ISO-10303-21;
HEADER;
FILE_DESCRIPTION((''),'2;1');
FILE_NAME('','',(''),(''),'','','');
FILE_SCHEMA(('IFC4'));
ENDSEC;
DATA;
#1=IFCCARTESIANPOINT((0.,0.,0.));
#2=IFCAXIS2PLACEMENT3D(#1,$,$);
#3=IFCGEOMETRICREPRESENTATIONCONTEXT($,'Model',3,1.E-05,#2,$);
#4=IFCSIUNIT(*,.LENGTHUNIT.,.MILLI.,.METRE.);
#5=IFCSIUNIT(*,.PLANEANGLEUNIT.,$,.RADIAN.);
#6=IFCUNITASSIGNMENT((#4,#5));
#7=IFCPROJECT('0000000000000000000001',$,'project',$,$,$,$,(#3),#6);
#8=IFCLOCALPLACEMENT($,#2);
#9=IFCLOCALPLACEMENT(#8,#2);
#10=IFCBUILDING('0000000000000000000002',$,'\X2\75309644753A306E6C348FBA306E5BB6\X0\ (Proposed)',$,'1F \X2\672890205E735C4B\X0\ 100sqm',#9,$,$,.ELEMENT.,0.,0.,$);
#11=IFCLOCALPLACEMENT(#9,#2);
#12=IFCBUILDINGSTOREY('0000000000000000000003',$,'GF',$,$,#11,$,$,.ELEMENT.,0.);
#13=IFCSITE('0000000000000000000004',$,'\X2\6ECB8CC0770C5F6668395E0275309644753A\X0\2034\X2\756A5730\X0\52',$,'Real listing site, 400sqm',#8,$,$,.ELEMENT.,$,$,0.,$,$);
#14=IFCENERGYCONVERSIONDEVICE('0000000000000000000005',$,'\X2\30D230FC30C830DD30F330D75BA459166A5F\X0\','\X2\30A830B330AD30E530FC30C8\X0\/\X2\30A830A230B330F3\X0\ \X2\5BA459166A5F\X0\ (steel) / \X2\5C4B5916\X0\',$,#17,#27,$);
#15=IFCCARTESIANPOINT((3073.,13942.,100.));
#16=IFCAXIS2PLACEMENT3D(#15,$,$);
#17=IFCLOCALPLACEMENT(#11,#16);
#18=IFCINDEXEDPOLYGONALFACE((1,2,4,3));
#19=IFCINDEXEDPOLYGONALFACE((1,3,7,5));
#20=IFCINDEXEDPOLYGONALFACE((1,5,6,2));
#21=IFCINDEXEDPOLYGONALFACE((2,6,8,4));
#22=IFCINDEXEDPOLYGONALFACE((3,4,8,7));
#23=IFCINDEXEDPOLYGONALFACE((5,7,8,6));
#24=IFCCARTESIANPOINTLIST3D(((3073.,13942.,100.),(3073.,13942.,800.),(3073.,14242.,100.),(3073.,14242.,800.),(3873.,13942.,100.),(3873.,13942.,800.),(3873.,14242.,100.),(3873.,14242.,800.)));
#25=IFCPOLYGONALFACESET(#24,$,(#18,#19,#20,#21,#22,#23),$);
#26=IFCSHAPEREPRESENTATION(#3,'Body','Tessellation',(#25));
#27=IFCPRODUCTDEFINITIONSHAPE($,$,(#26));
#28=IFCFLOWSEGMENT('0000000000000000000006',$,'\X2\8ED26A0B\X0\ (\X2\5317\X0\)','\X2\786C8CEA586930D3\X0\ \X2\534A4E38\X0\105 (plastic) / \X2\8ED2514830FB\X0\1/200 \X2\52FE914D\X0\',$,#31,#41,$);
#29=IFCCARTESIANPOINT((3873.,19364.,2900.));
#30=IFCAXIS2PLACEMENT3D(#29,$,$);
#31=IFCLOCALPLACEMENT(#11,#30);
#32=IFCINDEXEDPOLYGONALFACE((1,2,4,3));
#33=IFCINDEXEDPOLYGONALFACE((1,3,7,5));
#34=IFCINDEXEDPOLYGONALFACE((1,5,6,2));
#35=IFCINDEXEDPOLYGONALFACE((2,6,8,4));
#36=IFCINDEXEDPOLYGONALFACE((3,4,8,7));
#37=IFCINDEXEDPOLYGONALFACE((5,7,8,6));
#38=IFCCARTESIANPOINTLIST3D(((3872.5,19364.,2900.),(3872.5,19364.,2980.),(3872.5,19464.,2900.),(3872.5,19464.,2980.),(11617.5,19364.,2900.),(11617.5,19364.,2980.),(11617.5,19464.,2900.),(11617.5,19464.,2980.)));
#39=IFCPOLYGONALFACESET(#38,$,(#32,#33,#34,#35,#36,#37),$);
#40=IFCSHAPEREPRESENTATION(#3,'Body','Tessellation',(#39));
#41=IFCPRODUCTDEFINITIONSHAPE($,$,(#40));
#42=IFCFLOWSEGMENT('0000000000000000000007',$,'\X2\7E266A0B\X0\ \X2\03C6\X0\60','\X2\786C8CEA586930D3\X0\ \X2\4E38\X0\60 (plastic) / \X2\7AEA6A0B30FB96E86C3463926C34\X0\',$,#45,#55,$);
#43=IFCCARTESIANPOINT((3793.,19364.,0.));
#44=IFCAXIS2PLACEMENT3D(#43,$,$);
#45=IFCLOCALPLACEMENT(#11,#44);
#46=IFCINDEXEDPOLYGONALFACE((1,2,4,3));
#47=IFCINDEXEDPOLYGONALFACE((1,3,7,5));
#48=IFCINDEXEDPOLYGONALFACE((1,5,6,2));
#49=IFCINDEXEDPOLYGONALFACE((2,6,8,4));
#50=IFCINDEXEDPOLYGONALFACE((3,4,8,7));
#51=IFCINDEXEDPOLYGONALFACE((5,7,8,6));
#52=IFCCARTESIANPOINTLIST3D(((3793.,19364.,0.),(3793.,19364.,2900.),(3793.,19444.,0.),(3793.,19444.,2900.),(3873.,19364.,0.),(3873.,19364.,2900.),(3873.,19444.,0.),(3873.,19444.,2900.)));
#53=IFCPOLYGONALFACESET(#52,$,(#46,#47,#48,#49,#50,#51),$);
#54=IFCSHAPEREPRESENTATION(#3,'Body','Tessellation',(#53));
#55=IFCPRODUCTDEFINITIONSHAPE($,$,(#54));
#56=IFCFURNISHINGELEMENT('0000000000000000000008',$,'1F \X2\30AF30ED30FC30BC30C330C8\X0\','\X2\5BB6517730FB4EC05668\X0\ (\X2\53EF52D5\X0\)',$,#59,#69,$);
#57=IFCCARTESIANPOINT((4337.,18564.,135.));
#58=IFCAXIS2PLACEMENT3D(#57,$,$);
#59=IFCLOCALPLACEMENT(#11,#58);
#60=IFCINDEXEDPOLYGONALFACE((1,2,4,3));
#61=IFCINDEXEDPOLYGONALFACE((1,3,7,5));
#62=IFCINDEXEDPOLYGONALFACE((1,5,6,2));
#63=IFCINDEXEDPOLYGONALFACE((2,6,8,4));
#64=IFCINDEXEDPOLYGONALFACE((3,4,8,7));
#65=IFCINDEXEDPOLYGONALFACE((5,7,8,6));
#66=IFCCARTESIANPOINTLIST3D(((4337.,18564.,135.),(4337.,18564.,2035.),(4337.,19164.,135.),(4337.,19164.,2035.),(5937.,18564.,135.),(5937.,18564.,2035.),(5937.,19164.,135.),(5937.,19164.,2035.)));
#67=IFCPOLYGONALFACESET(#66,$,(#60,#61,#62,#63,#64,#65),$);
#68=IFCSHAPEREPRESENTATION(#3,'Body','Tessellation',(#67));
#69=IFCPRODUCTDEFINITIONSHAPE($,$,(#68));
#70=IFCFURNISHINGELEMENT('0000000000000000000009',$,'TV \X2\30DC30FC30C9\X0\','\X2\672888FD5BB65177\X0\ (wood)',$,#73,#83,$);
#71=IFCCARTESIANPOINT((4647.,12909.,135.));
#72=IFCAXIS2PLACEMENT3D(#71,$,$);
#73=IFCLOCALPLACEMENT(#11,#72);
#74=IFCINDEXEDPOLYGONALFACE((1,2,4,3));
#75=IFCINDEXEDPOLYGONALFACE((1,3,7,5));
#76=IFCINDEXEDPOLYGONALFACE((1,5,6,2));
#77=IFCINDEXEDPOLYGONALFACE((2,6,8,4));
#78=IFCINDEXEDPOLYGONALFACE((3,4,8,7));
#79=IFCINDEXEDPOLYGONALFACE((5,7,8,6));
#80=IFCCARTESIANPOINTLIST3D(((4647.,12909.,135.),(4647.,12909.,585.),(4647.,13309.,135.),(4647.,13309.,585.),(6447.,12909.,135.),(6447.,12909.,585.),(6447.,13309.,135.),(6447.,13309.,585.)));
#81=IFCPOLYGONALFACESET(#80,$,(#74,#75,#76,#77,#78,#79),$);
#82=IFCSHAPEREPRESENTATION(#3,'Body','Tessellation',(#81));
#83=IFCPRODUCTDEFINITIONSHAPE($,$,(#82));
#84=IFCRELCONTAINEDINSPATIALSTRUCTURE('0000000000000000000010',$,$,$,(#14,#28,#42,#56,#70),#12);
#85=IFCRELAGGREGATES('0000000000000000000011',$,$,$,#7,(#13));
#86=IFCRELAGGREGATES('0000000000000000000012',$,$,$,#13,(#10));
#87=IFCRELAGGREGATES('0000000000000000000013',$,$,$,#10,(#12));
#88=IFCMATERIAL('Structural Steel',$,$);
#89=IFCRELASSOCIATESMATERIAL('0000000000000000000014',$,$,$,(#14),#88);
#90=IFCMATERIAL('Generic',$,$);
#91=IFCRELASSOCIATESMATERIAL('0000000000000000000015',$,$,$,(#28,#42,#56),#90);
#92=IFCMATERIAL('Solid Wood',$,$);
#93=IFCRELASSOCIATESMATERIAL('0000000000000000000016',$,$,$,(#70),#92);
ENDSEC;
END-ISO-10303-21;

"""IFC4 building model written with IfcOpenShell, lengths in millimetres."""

from ifc_helpers import new_model, si_unit, frame, frame_2d, origin, place, context, project, spatial, rectangle, extrude, material, element, save


model = new_model("IFC4")

# Units and contexts
model_context = context("Model", 3, precision=1e-05, world=origin())
ifc_project = project(units=[si_unit("LENGTHUNIT", "METRE", prefix="MILLI"), si_unit("PLANEANGLEUNIT", "RADIAN")], contexts=[model_context])

# Site, building, storey
site_placement = place(None, origin())
site = spatial("IfcSite", under=ifc_project, at=site_placement, Name="滋賀県彦根市田附町2034番地52", ObjectType="Real listing site, 400sqm", CompositionType="ELEMENT", RefElevation=0.0)
building_placement = place(site_placement, origin())
building = spatial("IfcBuilding", under=site, at=building_placement, Name="田附町の水辺の家 (Proposed)", ObjectType="1F 木造平屋 100sqm", CompositionType="ELEMENT", ElevationOfRefHeight=0.0, ElevationOfTerrain=0.0)
storey_placement = place(building_placement, origin())
storey = spatial("IfcBuildingStorey", under=building, at=storey_placement, Name="GF", CompositionType="ELEMENT", Elevation=0.0)

# Shared definitions
ifc_material_1 = material(Name="Solid Wood")

# Shared definitions
ifc_material_2 = material(Name="Structural Steel")

# Shared definitions
ifc_material_3 = material(Name="Generic")

# Energy conversion device
energy_conversion_device_placement = place(storey_placement, frame((3073.0, 13942.0, 100.0)))
element("IfcEnergyConversionDevice", 1, at=energy_conversion_device_placement, inside=storey, material=ifc_material_2, Name="ヒートポンプ室外機", Description="エコキュート/エアコン 室外機 (steel) / 屋外", context=model_context, shape_type="SweptSolid", body=[
    extrude(rectangle(XDim=800.0, YDim=300.0, at=frame_2d((400.0, 150.0))), frame((3073.0, 13942.0, 100.0)), (0.0, 0.0, 1.0), 700.0),
])

# Flow segments
flow_segment_1_placement = place(storey_placement, frame((3873.0, 19364.0, 2900.0)))
element("IfcFlowSegment", 2, at=flow_segment_1_placement, inside=storey, material=ifc_material_3, Name="軒樋 (北)", Description="硬質塩ビ 半丸105 (plastic) / 軒先・1/200 勾配", context=model_context, shape_type="SweptSolid", body=[
    extrude(rectangle(XDim=7745.0, YDim=100.0, at=frame_2d((3872.0, 50.0))), frame((3873.0, 19364.0, 2900.0)), (0.0, 0.0, 1.0), 80.0),
])
flow_segment_2_placement = place(storey_placement, frame((3793.0, 19364.0, 0.0)))
element("IfcFlowSegment", 3, at=flow_segment_2_placement, inside=storey, material=ifc_material_3, Name="縦樋 φ60", Description="硬質塩ビ 丸60 (plastic) / 竪樋・雨水排水", context=model_context, shape_type="SweptSolid", body=[
    extrude(rectangle(XDim=80.0, YDim=80.0, at=frame_2d((40.0, 40.0))), frame((3793.0, 19364.0, 0.0)), (0.0, 0.0, 1.0), 2900.0),
])

# Furnishing elements
furnishing_1_placement = place(storey_placement, frame((4337.0, 18564.0, 135.0)))
element("IfcFurnishingElement", 4, at=furnishing_1_placement, inside=storey, material=ifc_material_3, Name="1F クローゼット", Description="家具・什器 (可動)", context=model_context, shape_type="SweptSolid", body=[
    extrude(rectangle(XDim=1600.0, YDim=600.0, at=frame_2d((800.0, 300.0))), frame((4337.0, 18564.0, 135.0)), (0.0, 0.0, 1.0), 1900.0),
])
furnishing_2_placement = place(storey_placement, frame((4647.0, 12909.0, 135.0)))
element("IfcFurnishingElement", 5, at=furnishing_2_placement, inside=storey, material=ifc_material_1, Name="TV ボード", Description="木製家具 (wood)", context=model_context, shape_type="SweptSolid", body=[
    extrude(rectangle(XDim=1800.0, YDim=400.0, at=frame_2d((900.0, 200.0))), frame((4647.0, 12909.0, 135.0)), (0.0, 0.0, 1.0), 450.0),
])

save(model, "model.ifc")
